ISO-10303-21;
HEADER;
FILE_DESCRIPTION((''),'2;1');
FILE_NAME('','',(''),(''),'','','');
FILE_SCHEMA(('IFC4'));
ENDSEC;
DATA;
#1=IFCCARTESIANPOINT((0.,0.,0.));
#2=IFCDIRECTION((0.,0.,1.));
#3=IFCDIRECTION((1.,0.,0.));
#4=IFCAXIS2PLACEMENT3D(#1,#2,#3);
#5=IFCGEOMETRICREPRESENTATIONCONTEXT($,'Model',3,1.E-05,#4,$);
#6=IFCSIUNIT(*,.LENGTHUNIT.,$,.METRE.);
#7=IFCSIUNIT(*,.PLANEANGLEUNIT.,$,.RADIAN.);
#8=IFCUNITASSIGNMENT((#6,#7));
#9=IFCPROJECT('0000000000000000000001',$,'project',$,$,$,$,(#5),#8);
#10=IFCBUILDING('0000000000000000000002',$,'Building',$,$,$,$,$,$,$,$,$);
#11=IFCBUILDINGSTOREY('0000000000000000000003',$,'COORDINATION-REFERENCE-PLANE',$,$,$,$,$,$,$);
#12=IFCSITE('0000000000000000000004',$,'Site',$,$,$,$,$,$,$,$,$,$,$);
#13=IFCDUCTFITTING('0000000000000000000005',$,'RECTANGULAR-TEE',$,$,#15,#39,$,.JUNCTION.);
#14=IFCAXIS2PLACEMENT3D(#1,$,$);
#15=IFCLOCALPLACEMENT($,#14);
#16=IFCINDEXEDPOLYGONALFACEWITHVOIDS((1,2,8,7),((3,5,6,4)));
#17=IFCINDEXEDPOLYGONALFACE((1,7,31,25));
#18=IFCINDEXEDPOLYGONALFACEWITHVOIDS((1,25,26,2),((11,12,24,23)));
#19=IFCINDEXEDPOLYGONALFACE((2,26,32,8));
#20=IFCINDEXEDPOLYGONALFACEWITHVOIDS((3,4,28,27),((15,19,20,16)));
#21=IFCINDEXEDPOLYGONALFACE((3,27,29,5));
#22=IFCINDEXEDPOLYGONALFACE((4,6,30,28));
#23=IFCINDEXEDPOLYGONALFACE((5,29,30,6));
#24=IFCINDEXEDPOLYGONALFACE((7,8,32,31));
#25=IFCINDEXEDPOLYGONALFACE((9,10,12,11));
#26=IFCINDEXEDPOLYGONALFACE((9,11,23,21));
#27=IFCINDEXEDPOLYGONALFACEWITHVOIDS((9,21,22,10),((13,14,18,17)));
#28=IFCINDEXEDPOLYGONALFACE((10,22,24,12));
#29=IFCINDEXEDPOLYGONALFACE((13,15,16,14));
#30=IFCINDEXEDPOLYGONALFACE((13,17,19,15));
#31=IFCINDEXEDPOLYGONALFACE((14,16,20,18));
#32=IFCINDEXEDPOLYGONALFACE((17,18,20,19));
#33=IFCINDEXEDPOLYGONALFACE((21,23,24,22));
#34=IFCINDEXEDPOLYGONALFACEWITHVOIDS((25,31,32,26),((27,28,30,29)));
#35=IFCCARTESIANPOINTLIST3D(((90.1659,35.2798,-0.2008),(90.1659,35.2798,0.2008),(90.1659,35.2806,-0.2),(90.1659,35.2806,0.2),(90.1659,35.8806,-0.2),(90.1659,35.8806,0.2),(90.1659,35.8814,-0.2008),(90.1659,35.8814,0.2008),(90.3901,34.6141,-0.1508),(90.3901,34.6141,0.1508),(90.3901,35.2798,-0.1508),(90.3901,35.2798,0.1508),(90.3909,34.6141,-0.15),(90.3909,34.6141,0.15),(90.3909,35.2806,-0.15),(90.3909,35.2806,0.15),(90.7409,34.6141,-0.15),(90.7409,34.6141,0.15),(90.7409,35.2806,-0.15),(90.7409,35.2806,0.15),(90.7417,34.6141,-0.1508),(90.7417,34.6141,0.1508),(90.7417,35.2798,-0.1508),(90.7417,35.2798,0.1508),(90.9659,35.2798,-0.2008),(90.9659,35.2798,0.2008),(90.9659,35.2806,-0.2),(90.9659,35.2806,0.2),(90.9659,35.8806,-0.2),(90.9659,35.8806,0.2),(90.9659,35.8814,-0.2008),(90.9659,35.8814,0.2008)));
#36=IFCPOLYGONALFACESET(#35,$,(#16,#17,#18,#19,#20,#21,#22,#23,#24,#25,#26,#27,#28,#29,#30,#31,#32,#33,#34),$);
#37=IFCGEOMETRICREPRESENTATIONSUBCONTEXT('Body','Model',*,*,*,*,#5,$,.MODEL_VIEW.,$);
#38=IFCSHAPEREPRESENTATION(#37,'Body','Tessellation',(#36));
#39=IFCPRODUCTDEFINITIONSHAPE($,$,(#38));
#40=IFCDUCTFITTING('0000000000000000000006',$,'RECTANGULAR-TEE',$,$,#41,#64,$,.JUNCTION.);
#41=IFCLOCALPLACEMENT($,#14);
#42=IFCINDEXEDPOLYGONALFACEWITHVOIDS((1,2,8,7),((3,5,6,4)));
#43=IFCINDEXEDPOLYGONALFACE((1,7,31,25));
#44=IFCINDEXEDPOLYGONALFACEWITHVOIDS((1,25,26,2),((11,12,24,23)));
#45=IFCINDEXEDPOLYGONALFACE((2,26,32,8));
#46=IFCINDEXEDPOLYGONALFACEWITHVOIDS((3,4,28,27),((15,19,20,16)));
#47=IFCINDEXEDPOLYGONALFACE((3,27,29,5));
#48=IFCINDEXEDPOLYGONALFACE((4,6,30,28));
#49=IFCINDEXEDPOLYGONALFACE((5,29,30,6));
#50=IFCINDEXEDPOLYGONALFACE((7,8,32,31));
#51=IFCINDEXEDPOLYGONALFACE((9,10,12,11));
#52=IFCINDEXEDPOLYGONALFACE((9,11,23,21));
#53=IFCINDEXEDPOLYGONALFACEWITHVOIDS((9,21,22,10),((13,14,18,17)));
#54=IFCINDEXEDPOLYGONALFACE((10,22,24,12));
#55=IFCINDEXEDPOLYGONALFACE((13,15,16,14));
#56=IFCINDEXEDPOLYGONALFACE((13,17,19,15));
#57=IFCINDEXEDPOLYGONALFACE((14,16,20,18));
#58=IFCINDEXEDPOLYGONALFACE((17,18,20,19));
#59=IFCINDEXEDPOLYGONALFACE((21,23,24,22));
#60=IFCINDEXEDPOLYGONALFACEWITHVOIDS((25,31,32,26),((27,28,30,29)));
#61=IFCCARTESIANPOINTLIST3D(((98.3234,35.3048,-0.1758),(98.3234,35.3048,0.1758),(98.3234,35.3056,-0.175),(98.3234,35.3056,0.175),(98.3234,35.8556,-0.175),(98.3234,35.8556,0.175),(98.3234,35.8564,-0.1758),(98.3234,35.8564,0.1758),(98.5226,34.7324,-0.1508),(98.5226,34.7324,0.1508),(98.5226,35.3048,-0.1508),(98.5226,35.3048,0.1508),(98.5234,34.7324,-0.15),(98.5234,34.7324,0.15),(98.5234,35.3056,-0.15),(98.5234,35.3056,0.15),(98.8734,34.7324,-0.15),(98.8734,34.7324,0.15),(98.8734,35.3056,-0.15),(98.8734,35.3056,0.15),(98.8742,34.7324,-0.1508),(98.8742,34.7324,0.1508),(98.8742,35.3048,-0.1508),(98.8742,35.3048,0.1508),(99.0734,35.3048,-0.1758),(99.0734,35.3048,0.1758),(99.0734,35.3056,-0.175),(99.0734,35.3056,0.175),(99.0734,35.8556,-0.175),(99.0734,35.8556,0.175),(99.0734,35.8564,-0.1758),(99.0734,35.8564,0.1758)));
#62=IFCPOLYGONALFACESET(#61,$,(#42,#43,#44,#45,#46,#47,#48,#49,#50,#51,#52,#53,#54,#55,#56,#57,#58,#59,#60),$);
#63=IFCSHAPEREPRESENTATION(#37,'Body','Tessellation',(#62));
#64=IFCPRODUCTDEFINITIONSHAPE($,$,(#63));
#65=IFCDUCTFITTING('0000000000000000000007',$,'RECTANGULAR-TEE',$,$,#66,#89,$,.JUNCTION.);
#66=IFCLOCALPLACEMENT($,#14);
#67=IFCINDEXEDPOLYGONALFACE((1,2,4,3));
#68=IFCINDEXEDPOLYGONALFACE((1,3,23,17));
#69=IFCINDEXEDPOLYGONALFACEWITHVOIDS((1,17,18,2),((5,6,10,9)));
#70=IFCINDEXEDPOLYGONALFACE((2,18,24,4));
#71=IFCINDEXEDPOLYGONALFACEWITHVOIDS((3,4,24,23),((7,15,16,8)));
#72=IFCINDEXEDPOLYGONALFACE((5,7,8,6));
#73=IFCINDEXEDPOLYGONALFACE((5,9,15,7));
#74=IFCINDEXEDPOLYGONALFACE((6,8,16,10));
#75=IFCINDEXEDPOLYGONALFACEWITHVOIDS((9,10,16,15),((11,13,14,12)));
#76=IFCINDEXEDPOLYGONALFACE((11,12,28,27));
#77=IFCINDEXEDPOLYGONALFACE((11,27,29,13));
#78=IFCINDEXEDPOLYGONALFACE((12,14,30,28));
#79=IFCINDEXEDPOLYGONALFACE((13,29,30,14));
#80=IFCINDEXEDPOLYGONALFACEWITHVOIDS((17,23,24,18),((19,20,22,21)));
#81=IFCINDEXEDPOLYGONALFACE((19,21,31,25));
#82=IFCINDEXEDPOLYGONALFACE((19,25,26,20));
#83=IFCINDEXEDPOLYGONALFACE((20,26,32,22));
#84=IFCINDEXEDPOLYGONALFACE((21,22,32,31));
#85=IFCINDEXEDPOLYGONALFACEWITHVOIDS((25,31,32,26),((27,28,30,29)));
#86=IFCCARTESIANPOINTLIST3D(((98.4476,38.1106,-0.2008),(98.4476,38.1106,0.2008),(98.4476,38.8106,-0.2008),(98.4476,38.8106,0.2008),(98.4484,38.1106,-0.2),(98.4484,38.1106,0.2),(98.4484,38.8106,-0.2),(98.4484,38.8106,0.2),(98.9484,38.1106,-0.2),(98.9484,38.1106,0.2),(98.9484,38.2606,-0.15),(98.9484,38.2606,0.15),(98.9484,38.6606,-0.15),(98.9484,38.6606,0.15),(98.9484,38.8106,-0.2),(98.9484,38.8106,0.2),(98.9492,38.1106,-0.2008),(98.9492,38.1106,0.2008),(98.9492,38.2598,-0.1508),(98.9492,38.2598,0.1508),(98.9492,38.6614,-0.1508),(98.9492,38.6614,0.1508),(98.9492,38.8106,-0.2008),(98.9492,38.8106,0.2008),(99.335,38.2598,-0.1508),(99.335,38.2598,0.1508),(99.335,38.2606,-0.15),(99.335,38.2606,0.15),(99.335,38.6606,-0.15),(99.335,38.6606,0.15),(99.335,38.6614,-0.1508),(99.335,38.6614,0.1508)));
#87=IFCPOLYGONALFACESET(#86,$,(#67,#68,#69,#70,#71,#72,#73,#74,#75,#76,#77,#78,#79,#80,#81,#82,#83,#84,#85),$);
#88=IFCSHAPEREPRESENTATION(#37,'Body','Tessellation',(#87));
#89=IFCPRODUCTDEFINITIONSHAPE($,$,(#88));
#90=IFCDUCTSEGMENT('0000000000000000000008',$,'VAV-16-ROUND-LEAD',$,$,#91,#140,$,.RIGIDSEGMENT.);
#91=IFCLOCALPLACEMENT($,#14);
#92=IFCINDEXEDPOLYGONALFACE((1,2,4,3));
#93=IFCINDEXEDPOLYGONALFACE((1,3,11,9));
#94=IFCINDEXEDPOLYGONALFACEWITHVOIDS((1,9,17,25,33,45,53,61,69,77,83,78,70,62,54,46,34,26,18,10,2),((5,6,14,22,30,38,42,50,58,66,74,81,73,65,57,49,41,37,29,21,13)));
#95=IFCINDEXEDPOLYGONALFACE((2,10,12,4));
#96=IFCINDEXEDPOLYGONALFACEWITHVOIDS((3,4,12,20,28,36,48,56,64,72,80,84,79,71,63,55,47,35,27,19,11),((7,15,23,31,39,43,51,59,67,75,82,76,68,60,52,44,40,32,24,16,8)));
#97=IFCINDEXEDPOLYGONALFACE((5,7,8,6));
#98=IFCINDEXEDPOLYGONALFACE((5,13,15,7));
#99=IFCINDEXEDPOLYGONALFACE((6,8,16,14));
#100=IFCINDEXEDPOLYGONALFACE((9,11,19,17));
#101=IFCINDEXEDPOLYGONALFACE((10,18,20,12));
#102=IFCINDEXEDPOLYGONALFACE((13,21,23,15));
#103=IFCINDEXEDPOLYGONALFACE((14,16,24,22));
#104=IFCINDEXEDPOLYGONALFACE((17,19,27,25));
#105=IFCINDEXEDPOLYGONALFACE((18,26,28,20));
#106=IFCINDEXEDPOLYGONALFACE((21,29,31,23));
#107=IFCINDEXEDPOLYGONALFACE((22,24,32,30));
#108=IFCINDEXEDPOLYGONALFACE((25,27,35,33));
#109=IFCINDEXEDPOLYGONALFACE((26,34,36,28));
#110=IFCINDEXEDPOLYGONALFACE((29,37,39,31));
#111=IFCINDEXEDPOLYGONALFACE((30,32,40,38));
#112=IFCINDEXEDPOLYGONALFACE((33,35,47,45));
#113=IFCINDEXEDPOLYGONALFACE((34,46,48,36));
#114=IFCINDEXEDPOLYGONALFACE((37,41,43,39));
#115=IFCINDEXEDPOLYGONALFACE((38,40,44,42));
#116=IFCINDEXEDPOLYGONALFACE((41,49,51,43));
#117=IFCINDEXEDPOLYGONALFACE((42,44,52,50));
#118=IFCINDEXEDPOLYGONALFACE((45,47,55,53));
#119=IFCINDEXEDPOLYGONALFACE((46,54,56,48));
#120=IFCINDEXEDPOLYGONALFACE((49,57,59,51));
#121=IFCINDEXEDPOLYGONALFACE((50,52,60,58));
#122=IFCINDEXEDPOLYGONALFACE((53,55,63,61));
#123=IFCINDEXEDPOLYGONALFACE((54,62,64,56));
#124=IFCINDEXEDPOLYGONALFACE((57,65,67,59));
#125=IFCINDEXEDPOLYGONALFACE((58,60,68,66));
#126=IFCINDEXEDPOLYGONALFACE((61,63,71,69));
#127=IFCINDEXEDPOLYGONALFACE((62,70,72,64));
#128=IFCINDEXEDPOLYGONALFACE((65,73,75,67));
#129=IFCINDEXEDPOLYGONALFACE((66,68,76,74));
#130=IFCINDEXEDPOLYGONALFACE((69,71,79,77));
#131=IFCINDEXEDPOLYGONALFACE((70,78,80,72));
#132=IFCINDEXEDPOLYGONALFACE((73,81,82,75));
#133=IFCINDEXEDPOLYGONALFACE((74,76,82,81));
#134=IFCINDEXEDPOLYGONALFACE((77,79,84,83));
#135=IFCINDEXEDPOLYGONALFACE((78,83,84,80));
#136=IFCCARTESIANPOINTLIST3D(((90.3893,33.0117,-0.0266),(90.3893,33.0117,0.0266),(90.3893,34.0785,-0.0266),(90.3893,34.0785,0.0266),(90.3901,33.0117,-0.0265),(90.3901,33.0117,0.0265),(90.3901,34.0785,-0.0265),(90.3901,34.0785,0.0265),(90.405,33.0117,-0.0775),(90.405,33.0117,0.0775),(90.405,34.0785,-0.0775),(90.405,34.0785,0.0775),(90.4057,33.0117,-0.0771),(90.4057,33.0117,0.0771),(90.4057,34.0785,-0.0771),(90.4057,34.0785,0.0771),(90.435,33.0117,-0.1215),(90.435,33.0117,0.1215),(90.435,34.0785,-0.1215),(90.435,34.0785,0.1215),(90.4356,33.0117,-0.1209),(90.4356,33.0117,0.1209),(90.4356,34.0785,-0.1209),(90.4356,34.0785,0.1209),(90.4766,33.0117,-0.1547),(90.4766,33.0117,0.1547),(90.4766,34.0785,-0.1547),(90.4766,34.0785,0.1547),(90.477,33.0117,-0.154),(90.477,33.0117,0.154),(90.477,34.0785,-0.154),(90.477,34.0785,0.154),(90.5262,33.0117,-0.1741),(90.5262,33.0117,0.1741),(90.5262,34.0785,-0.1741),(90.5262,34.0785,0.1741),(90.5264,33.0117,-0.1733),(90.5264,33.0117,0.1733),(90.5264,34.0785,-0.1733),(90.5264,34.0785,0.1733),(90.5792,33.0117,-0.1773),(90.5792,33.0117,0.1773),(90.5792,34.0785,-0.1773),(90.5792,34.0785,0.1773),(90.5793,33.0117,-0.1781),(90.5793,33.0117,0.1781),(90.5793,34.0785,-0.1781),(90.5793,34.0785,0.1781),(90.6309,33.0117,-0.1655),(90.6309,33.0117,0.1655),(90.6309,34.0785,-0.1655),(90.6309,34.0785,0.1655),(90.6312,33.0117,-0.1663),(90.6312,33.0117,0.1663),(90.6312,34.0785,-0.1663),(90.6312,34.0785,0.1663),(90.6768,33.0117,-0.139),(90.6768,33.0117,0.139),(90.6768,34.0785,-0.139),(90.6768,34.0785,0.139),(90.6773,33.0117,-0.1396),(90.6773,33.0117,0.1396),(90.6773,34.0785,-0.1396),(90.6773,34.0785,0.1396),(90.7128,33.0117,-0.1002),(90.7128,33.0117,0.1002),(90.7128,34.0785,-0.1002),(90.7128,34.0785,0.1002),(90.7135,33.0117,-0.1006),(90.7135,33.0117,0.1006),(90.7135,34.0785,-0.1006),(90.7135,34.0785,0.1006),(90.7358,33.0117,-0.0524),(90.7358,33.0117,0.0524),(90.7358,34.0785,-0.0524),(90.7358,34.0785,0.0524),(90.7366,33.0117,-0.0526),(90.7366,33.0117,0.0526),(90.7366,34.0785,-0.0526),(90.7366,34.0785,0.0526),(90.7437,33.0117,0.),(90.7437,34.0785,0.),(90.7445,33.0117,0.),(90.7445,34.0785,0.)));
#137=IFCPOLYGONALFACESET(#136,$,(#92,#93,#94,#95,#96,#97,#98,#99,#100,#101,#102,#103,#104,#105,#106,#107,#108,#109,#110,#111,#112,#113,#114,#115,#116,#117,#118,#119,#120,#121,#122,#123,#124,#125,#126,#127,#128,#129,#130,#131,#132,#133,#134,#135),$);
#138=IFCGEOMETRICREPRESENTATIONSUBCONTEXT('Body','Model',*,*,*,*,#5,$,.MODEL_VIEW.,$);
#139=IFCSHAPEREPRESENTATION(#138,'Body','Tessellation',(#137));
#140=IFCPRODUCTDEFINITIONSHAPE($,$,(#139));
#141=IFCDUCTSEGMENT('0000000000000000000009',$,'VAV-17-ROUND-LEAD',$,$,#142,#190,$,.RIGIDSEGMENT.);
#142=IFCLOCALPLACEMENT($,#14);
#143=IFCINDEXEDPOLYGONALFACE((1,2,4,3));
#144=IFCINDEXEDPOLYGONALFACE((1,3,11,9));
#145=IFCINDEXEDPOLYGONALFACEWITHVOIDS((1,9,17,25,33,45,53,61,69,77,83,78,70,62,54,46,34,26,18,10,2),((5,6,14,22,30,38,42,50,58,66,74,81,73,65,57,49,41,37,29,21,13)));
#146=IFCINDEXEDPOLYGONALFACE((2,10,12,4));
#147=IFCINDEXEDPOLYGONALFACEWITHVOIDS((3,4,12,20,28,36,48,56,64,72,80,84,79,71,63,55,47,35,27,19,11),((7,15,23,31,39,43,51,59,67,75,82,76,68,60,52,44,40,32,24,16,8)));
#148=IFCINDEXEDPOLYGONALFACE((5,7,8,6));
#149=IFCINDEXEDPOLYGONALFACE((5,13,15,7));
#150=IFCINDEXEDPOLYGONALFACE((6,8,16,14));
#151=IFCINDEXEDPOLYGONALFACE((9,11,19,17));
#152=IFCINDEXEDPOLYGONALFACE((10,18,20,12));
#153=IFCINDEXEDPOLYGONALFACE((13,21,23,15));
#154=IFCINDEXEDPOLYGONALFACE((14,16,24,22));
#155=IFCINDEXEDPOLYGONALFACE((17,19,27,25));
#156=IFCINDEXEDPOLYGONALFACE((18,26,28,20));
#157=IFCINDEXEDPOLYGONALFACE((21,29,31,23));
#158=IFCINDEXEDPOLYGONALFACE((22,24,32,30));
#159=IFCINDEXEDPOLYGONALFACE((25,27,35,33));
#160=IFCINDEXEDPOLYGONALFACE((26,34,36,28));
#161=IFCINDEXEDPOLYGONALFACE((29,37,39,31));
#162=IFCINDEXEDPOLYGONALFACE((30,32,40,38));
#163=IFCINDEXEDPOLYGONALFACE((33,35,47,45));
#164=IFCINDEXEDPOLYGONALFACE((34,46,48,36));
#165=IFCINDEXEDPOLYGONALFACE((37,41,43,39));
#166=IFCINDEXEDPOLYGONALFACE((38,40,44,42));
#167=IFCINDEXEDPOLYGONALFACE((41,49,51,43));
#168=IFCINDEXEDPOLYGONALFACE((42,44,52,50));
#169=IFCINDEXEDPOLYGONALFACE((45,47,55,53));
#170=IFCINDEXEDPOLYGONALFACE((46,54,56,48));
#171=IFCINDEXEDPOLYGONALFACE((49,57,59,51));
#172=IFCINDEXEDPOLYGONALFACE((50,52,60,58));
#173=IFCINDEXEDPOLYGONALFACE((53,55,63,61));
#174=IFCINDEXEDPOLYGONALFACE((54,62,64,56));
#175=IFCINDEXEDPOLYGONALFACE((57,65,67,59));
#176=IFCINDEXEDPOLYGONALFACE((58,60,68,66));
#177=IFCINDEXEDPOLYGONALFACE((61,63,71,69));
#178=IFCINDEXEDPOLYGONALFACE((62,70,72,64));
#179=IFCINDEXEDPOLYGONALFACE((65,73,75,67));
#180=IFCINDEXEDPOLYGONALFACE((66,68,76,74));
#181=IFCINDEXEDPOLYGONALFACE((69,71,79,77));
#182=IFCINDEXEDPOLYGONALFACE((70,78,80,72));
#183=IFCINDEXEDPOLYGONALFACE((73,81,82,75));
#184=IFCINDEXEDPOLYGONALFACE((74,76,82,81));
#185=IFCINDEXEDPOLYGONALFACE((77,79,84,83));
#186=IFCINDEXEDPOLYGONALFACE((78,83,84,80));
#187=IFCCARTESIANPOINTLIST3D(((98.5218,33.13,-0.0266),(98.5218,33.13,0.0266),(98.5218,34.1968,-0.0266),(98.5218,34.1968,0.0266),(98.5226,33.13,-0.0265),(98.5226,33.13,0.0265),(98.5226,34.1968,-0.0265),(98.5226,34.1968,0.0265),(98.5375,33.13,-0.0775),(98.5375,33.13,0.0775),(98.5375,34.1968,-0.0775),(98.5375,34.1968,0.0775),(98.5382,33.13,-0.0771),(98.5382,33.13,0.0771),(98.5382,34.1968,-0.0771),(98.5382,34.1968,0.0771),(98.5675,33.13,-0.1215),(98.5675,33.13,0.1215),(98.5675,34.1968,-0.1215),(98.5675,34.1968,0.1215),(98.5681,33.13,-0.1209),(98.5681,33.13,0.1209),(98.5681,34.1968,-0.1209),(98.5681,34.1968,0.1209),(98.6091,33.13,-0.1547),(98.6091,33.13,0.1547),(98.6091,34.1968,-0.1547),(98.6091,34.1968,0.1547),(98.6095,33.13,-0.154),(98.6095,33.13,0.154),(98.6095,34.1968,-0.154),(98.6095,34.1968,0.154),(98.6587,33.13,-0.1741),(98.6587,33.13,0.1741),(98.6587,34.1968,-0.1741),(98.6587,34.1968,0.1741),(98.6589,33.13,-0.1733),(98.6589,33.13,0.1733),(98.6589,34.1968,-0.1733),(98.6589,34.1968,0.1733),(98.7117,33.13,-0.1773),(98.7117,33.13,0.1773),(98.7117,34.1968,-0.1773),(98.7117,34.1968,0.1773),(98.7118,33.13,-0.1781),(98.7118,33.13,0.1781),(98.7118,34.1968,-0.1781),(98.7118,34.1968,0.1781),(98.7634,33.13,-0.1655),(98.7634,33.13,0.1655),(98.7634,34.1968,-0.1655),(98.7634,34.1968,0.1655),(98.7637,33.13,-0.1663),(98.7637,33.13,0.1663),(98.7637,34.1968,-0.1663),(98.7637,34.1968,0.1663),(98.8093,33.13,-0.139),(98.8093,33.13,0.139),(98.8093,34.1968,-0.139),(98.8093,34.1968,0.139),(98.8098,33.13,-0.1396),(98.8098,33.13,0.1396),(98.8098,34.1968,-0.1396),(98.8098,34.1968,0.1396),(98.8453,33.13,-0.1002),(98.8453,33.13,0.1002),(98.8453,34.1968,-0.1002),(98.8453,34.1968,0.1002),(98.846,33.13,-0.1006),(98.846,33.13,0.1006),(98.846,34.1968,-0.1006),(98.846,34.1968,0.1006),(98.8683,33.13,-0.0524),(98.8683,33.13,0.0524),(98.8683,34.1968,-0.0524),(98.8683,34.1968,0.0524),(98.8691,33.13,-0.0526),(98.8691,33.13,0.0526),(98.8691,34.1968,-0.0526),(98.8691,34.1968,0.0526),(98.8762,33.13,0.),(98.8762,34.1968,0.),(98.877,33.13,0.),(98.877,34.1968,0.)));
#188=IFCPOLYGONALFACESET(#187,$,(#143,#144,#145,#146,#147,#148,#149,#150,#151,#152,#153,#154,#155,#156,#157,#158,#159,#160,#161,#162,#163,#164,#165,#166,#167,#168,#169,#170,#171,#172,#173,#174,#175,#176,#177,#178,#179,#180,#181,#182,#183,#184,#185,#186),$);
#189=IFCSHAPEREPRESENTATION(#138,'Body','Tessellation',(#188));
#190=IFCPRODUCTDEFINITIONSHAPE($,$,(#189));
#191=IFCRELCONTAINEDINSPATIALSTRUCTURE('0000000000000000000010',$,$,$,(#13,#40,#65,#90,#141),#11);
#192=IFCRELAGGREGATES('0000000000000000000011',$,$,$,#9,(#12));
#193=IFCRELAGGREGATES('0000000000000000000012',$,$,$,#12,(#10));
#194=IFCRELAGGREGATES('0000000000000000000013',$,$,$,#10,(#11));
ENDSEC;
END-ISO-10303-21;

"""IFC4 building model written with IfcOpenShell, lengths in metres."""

from ifc_helpers import new_model, si_unit, frame, origin, origin_with_axes, place, context, subcontext, project, spatial, rectangle, hollow_circle, extrude, boolean, element, save


model = new_model("IFC4")

# Units and contexts
model_context = context("Model", 3, precision=1e-05, world=origin_with_axes())
body_context_1 = subcontext(model_context, "Body", "Model", "MODEL_VIEW")
body_context_2 = subcontext(model_context, "Body", "Model", "MODEL_VIEW")
ifc_project = project(units=[si_unit("LENGTHUNIT", "METRE"), si_unit("PLANEANGLEUNIT", "RADIAN")], contexts=[model_context])

# Site, building, storey
site = spatial("IfcSite", under=ifc_project, Name="Site")
building = spatial("IfcBuilding", under=site, Name="Building")
storey = spatial("IfcBuildingStorey", under=building, Name="COORDINATION-REFERENCE-PLANE")

# Duct fittings
duct_fitting_1_placement = place(None, frame((90.5659, 35.5806, 0.0), z_axis=(1.0, 0.0, 0.0), x_axis=(0.0, -1.0, 0.0)))
solid_1 = boolean("UNION", extrude(rectangle(XDim=0.6, YDim=0.4), frame((0.0, 0.0, -0.4), z_axis=(0.0, 0.0, 1.0), x_axis=(1.0, 0.0, 0.0)), (0.0, 0.0, 1.0), 0.8), extrude(rectangle(XDim=0.35, YDim=0.3), frame((0.0, 0.0, 0.0), z_axis=(1.0, 0.0, 0.0), x_axis=(0.0, 0.0, -1.0)), (0.0, 0.0, 1.0), 0.9665))
element("IfcDuctFitting", 1, at=duct_fitting_1_placement, inside=storey, Name="RECTANGULAR-TEE", PredefinedType="JUNCTION", context=body_context_1, shape_type="CSG", body=[
    boolean("DIFFERENCE", boolean("UNION", extrude(rectangle(XDim=0.6016, YDim=0.4016), frame((0.0, 0.0, -0.4), z_axis=(0.0, 0.0, 1.0), x_axis=(1.0, 0.0, 0.0)), (0.0, 0.0, 1.0), 0.8), extrude(rectangle(XDim=0.3516, YDim=0.3016), frame((0.0, 0.0, 0.0), z_axis=(1.0, 0.0, 0.0), x_axis=(0.0, 0.0, -1.0)), (0.0, 0.0, 1.0), 0.9665)), solid_1),
])
duct_fitting_2_placement = place(None, frame((98.6984, 35.5806, 0.0), z_axis=(1.0, 0.0, 0.0), x_axis=(0.0, -1.0, 0.0)))
solid_2 = boolean("UNION", extrude(rectangle(XDim=0.55, YDim=0.35), frame((0.0, 0.0, -0.375), z_axis=(0.0, 0.0, 1.0), x_axis=(1.0, 0.0, 0.0)), (0.0, 0.0, 1.0), 0.75), extrude(rectangle(XDim=0.35, YDim=0.3), frame((0.0, 0.0, 0.0), z_axis=(1.0, 0.0, 0.0), x_axis=(0.0, 0.0, -1.0)), (0.0, 0.0, 1.0), 0.8482))
element("IfcDuctFitting", 2, at=duct_fitting_2_placement, inside=storey, Name="RECTANGULAR-TEE", PredefinedType="JUNCTION", context=body_context_1, shape_type="CSG", body=[
    boolean("DIFFERENCE", boolean("UNION", extrude(rectangle(XDim=0.5516, YDim=0.3516), frame((0.0, 0.0, -0.375), z_axis=(0.0, 0.0, 1.0), x_axis=(1.0, 0.0, 0.0)), (0.0, 0.0, 1.0), 0.75), extrude(rectangle(XDim=0.3516, YDim=0.3016), frame((0.0, 0.0, 0.0), z_axis=(1.0, 0.0, 0.0), x_axis=(0.0, 0.0, -1.0)), (0.0, 0.0, 1.0), 0.8482)), solid_2),
])
duct_fitting_3_placement = place(None, frame((98.6984, 38.4606, 0.0), z_axis=(0.0, 1.0, 0.0), x_axis=(1.0, 0.0, 0.0)))
solid_3 = boolean("UNION", extrude(rectangle(XDim=0.5, YDim=0.4), frame((0.0, 0.0, -0.35), z_axis=(0.0, 0.0, 1.0), x_axis=(1.0, 0.0, 0.0)), (0.0, 0.0, 1.0), 0.7), extrude(rectangle(XDim=0.4, YDim=0.3), frame((0.0, 0.0, 0.0), z_axis=(1.0, 0.0, 0.0), x_axis=(0.0, 0.0, -1.0)), (0.0, 0.0, 1.0), 0.6366))
element("IfcDuctFitting", 3, at=duct_fitting_3_placement, inside=storey, Name="RECTANGULAR-TEE", PredefinedType="JUNCTION", context=body_context_1, shape_type="CSG", body=[
    boolean("DIFFERENCE", boolean("UNION", extrude(rectangle(XDim=0.5016, YDim=0.4016), frame((0.0, 0.0, -0.35), z_axis=(0.0, 0.0, 1.0), x_axis=(1.0, 0.0, 0.0)), (0.0, 0.0, 1.0), 0.7), extrude(rectangle(XDim=0.4016, YDim=0.3016), frame((0.0, 0.0, 0.0), z_axis=(1.0, 0.0, 0.0), x_axis=(0.0, 0.0, -1.0)), (0.0, 0.0, 1.0), 0.6366)), solid_3),
])

# Duct segments
for number, where, z_axis, x_axis, name in (
    (4, (90.5659, 34.0785, 0.0), (0.0, -1.0, 0.0), (1.0, 0.0, 0.0), "VAV-16-ROUND-LEAD"),
    (5, (98.6984, 34.1968, 0.0), (0.0, -1.0, 0.0), (1.0, 0.0, 0.0), "VAV-17-ROUND-LEAD"),
):
    element("IfcDuctSegment", number, at=place(None, frame(where, z_axis=z_axis, x_axis=x_axis)), inside=storey, Name=name, PredefinedType="RIGIDSEGMENT", context=body_context_2, shape_type="SweptSolid", body=[
        extrude(hollow_circle(Radius=0.1786, WallThickness=0.0008), origin(), (0.0, 0.0, 1.0), 1.0668),
    ])

save(model, "model.ifc")
